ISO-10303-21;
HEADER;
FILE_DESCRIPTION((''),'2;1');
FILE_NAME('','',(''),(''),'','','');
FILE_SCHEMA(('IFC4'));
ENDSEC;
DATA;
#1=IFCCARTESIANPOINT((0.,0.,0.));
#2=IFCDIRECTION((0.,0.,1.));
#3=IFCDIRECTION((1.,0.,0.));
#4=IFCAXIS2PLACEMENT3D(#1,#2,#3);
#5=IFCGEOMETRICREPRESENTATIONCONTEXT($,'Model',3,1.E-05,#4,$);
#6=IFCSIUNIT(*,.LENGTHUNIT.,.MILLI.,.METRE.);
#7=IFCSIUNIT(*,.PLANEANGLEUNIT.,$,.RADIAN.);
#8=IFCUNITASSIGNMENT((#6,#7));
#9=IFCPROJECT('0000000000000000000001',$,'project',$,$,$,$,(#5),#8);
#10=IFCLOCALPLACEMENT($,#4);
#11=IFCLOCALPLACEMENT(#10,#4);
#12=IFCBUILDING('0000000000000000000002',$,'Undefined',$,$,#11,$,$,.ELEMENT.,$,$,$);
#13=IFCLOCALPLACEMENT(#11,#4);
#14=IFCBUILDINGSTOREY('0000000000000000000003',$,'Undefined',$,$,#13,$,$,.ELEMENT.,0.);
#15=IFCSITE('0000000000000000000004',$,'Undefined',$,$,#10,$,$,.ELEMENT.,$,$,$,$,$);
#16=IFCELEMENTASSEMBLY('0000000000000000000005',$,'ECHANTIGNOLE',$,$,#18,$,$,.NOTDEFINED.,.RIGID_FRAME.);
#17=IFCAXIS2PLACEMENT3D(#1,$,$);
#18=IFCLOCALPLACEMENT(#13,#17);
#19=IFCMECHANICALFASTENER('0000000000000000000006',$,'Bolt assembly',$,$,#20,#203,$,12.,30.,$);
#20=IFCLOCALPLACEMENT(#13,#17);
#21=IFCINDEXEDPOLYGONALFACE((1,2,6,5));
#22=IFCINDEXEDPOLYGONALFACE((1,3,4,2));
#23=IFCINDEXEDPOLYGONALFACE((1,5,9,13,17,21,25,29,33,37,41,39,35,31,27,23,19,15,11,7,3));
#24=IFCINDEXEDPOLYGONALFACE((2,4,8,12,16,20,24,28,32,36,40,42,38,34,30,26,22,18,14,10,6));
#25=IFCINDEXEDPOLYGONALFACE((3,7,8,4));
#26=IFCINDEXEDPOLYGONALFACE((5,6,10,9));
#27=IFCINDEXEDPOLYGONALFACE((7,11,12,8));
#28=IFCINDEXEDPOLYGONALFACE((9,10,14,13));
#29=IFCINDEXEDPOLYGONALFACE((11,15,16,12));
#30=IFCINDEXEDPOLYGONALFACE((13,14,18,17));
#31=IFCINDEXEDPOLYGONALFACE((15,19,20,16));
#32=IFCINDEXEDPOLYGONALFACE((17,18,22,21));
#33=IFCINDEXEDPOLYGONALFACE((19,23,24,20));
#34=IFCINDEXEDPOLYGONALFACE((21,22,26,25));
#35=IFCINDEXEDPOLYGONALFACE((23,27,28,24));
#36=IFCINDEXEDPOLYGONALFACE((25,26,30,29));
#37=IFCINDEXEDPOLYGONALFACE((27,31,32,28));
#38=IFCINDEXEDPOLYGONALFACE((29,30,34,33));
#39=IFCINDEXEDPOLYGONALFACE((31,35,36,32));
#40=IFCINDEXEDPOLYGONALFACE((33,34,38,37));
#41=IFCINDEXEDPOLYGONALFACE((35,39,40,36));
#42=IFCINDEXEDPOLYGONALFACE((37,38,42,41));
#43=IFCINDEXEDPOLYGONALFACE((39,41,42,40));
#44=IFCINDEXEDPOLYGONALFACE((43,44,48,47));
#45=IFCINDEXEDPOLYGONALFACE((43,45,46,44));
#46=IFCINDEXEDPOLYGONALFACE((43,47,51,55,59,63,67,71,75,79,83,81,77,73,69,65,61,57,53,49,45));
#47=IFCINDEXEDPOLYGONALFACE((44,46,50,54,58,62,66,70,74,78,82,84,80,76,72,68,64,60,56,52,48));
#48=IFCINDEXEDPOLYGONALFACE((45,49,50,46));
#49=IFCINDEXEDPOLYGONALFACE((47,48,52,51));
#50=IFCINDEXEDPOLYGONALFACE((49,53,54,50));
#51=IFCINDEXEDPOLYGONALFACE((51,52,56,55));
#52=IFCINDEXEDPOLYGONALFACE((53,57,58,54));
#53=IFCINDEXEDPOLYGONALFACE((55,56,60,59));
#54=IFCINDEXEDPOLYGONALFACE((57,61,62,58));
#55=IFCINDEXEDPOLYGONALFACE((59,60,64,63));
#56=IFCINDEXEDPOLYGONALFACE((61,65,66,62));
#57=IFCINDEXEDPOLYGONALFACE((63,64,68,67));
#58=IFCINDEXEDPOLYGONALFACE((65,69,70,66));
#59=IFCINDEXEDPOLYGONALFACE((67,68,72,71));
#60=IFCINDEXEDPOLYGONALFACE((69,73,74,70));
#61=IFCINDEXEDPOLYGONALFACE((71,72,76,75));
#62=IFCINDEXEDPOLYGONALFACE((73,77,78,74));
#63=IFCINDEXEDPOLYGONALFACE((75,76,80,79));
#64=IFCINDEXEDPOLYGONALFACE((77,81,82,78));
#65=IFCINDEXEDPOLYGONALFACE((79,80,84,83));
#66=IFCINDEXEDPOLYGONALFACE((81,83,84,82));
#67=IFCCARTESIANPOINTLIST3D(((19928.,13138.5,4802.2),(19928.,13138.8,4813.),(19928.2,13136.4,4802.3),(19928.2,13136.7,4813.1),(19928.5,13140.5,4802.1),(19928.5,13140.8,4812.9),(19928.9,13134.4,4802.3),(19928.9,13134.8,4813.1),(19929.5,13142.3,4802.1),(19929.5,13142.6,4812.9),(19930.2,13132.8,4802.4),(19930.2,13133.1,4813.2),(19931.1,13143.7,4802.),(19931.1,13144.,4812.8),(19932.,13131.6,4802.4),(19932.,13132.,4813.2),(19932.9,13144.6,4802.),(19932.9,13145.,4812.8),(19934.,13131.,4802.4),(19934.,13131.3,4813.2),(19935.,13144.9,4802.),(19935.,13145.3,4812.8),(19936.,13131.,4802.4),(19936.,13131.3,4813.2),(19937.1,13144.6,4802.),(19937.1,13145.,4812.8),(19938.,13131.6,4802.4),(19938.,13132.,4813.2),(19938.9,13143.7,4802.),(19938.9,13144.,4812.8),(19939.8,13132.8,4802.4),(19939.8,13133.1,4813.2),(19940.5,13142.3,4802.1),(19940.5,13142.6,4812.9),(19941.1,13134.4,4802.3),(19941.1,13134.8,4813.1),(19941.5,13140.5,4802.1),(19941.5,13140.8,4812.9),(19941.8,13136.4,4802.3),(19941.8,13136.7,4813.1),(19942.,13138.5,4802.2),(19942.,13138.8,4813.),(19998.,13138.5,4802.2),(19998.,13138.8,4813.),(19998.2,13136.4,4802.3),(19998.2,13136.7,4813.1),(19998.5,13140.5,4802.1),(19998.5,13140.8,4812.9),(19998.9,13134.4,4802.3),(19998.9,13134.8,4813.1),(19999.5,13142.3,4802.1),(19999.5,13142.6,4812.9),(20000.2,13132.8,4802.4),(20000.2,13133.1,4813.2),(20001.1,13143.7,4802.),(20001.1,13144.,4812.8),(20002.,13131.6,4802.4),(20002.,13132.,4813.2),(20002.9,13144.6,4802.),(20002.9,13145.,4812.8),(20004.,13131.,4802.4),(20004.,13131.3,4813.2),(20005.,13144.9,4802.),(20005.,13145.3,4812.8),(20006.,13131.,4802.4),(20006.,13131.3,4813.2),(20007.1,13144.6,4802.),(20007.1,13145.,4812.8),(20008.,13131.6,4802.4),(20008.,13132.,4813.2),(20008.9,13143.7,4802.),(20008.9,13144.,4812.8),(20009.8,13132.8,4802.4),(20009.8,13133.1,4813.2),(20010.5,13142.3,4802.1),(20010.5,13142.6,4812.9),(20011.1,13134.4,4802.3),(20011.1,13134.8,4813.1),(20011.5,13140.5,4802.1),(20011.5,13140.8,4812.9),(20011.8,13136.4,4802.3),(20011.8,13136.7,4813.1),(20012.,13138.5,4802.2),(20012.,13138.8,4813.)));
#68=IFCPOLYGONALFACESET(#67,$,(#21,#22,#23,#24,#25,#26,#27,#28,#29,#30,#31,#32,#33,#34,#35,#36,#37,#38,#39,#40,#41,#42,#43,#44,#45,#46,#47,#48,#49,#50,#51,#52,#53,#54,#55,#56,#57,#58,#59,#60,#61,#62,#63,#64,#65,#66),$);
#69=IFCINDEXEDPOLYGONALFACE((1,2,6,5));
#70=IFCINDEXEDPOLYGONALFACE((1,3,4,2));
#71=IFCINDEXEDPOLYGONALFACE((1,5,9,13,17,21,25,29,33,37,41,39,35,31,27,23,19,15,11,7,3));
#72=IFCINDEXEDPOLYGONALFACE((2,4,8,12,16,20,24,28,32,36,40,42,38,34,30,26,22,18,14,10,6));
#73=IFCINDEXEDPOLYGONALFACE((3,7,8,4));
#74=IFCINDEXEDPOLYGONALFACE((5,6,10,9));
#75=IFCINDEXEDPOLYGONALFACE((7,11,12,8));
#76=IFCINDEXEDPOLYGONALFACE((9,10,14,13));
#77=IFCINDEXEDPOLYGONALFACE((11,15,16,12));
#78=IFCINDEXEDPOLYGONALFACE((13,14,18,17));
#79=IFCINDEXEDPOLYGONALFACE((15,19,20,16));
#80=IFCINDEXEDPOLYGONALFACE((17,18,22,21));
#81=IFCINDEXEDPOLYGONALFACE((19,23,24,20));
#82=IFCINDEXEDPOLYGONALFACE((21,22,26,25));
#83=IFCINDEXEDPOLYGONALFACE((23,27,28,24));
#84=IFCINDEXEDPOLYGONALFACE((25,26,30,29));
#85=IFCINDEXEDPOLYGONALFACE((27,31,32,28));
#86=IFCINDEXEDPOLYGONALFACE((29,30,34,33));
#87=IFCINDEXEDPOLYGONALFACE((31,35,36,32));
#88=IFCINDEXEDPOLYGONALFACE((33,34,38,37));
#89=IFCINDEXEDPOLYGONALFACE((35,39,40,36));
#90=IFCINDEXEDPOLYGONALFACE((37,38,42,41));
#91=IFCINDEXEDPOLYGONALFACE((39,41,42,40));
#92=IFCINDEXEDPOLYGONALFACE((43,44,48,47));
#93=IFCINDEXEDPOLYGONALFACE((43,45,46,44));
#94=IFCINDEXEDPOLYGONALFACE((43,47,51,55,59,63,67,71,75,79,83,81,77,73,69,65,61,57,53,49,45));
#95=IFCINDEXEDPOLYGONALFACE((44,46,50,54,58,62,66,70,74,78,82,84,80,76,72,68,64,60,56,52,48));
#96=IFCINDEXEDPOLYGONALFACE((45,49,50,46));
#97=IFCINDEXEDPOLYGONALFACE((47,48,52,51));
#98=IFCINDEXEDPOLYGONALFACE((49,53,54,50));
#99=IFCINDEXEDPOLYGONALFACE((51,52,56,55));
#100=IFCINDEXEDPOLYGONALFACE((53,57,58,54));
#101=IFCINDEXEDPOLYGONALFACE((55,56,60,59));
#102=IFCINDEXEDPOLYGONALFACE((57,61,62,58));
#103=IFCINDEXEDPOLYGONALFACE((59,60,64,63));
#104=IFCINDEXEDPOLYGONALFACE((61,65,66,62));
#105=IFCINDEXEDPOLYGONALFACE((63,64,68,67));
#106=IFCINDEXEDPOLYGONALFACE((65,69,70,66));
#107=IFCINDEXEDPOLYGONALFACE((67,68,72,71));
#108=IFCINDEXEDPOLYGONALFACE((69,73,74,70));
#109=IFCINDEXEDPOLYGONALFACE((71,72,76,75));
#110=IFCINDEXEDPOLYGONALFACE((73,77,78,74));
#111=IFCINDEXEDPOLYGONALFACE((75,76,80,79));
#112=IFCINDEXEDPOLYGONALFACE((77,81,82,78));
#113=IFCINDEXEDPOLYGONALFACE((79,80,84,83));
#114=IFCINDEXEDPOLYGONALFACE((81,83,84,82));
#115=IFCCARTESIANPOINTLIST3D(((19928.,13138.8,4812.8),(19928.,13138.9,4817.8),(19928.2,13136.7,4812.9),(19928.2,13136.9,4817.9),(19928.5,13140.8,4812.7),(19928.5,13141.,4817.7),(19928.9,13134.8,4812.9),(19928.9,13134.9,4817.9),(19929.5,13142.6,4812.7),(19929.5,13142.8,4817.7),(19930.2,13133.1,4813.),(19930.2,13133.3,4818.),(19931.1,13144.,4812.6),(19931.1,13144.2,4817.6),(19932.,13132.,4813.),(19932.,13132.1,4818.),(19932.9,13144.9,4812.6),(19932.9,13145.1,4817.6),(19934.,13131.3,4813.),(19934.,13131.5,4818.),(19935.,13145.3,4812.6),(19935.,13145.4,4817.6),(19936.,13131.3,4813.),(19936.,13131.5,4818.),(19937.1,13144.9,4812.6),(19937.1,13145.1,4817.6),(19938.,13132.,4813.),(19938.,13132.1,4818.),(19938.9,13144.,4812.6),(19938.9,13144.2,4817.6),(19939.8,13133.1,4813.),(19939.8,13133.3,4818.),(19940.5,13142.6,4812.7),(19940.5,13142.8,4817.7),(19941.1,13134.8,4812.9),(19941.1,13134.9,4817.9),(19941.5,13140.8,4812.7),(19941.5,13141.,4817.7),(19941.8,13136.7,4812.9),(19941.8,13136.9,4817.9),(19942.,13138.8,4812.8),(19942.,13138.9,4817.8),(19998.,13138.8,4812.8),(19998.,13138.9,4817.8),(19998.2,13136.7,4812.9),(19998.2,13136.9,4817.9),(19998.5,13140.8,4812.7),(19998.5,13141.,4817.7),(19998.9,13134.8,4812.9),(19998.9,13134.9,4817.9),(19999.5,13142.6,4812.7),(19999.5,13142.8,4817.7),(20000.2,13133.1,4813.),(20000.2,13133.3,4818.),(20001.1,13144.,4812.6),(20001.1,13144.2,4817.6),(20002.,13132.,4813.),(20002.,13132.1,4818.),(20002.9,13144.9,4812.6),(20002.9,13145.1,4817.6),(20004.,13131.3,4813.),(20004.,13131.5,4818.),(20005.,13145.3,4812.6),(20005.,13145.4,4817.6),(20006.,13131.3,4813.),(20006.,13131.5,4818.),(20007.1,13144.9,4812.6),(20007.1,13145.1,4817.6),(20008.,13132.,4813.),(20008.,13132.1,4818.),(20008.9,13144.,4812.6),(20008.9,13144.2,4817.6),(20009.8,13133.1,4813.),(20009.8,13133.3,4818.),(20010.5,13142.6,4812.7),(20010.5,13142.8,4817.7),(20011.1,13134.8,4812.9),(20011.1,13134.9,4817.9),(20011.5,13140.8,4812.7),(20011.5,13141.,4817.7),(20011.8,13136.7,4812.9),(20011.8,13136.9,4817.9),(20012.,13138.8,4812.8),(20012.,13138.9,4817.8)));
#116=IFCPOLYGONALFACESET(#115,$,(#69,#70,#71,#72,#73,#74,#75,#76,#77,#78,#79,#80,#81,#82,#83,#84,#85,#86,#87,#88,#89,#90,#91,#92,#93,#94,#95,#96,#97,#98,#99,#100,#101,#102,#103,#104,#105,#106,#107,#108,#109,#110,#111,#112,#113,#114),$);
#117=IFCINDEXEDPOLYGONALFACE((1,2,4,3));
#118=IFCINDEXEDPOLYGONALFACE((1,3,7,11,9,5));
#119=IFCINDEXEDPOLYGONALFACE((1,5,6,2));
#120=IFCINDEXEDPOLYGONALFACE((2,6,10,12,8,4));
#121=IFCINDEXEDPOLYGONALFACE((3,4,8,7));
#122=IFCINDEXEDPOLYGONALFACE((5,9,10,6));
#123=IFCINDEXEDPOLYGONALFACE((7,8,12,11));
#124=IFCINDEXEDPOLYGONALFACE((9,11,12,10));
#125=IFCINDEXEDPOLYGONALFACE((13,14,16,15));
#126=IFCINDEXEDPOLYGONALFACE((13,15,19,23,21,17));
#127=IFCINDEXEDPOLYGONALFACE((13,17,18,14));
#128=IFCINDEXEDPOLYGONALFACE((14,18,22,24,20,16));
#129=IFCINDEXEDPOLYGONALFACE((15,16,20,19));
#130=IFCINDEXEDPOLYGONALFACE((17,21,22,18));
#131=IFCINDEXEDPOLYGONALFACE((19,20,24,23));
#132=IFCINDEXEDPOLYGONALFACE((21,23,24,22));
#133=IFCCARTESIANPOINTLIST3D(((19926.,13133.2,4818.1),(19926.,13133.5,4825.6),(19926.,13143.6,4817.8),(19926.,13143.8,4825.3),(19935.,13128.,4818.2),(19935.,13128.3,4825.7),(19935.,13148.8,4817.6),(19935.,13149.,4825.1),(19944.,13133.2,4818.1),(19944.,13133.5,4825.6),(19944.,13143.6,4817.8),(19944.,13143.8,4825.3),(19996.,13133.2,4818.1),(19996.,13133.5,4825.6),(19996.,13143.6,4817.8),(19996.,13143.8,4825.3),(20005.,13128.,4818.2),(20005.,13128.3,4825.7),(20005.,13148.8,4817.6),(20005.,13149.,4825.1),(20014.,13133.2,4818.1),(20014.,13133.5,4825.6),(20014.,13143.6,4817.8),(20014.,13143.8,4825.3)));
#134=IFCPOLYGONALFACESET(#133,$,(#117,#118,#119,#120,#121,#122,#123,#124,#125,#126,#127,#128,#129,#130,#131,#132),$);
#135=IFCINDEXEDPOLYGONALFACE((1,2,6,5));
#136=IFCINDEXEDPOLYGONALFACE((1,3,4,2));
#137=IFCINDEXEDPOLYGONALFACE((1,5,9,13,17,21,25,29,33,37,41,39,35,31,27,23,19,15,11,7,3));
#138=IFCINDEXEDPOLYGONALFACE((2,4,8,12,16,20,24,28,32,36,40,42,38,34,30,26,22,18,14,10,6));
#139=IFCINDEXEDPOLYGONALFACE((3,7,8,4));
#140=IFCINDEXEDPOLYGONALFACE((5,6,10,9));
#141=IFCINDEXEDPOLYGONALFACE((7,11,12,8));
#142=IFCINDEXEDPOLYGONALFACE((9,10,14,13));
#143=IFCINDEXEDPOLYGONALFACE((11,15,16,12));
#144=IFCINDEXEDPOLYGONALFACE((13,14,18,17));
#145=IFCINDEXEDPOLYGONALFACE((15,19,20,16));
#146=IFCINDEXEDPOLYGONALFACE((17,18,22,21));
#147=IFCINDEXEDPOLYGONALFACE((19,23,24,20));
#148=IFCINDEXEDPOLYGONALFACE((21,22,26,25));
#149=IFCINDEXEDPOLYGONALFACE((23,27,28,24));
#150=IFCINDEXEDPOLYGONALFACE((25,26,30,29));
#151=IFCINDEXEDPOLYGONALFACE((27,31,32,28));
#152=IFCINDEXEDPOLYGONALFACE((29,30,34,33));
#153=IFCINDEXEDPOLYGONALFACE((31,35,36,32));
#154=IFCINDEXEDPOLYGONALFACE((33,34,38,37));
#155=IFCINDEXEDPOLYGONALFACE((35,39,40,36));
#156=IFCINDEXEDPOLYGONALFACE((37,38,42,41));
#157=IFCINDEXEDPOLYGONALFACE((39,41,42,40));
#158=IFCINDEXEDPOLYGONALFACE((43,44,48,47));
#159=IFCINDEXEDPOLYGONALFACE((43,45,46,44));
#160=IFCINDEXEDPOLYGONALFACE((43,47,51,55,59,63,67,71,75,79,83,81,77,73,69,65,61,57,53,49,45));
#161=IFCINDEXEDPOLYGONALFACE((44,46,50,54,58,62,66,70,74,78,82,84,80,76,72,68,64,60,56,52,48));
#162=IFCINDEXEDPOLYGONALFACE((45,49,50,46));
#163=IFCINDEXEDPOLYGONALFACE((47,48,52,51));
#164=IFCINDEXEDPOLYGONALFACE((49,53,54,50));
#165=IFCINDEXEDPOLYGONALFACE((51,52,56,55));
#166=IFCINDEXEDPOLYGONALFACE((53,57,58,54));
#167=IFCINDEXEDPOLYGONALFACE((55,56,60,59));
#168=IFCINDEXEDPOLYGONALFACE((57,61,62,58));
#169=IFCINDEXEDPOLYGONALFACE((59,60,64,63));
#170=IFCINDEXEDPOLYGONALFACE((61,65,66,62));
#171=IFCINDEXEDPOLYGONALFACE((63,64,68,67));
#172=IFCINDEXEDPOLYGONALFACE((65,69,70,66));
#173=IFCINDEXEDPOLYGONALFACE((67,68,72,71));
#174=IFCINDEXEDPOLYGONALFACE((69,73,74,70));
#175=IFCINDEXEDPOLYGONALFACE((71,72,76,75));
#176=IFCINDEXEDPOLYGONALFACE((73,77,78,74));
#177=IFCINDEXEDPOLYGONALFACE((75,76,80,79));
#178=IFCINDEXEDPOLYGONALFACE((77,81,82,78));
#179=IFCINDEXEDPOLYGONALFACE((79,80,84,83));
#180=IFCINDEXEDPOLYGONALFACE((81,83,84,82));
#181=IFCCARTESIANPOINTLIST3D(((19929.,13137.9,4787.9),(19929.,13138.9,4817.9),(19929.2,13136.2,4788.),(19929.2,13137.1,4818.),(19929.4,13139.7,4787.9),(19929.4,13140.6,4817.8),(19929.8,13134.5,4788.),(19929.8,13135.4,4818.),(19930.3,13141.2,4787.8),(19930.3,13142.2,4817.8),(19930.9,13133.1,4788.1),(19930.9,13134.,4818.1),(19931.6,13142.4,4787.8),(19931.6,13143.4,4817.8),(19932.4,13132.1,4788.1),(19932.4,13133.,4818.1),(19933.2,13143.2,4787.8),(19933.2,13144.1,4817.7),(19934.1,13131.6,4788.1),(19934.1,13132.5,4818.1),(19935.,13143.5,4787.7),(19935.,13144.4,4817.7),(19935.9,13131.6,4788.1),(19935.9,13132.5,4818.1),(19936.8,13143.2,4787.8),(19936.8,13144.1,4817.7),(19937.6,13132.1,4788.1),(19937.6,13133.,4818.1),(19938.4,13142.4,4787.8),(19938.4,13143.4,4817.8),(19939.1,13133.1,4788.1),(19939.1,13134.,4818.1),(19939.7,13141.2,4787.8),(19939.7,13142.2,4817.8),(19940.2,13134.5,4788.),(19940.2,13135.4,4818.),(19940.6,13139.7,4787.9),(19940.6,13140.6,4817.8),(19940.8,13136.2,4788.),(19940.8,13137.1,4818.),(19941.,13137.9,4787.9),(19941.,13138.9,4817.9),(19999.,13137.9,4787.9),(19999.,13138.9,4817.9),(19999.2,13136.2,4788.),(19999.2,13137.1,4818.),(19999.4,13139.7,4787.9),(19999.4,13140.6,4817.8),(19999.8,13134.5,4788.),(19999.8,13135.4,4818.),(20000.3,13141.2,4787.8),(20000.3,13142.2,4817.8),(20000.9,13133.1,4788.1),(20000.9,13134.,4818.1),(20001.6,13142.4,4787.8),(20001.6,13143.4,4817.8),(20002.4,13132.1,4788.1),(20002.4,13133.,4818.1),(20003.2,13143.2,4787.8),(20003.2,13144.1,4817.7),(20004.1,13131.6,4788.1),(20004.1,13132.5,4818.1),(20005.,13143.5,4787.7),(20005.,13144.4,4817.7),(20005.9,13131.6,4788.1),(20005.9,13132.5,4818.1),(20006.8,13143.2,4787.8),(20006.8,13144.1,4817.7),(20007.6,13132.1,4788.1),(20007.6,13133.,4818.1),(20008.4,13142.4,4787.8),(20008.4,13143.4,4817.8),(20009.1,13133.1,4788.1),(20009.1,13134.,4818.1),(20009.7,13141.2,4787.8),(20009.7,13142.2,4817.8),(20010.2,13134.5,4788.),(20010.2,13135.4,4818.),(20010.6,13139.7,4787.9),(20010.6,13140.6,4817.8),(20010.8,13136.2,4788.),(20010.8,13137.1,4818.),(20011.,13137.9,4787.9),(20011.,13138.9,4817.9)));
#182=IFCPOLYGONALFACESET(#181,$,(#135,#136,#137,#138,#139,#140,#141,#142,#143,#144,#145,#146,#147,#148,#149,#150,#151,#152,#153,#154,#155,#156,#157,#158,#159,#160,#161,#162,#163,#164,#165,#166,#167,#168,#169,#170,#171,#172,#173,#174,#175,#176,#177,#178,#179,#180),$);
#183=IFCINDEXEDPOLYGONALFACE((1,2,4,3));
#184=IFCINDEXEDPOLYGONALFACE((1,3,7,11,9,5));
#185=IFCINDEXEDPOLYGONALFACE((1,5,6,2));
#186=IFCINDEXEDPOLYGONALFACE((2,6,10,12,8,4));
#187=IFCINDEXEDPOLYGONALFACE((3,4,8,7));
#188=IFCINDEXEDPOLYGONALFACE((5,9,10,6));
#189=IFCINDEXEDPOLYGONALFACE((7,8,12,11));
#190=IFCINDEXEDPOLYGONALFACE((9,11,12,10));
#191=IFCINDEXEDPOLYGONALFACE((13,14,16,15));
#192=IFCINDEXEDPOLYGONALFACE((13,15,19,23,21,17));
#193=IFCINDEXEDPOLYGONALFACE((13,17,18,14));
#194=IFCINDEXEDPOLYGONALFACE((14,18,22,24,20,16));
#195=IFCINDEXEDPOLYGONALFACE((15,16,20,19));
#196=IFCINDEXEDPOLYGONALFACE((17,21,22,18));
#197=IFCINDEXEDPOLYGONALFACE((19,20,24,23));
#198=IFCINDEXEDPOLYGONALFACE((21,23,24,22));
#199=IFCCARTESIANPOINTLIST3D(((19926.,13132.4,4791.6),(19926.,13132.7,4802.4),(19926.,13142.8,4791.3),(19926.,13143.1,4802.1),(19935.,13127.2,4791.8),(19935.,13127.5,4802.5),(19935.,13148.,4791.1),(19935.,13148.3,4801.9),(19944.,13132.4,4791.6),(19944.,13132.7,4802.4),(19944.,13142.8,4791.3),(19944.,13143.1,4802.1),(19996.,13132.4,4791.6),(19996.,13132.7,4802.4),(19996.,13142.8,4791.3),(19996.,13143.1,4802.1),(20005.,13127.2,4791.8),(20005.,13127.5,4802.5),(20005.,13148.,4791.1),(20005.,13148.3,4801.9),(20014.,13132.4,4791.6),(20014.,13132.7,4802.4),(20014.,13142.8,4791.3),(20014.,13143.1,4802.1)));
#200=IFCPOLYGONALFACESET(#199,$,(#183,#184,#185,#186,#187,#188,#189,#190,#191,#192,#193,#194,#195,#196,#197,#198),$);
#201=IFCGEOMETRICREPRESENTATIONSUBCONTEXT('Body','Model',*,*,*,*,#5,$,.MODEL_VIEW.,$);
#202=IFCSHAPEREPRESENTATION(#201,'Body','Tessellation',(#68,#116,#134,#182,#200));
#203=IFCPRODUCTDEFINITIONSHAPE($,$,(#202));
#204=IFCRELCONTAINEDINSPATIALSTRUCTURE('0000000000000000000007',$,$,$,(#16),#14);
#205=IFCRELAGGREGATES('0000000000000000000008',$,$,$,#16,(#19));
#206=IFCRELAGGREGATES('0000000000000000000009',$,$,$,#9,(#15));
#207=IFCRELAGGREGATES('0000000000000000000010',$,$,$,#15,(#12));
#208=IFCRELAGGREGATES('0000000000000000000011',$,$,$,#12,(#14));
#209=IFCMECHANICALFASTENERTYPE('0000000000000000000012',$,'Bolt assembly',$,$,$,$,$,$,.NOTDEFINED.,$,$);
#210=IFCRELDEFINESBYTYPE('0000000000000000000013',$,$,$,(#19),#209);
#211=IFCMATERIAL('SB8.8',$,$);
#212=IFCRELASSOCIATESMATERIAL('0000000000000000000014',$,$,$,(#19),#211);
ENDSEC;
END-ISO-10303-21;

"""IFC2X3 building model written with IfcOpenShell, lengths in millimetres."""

from ifc_helpers import new_model, si_unit, frame, origin_with_axes, origin_2d_with_axis, place, context, subcontext, project, spatial, polyline, circle, outline, extrude, source, transform, mapped, material, type_object, element, aggregate, save


model = new_model("IFC2X3")

# Units and contexts
model_context = context("Model", 3, precision=1e-05, world=origin_with_axes())
body_context = subcontext(model_context, "Body", "Model", "MODEL_VIEW")
ifc_project = project(units=[si_unit("LENGTHUNIT", "METRE", prefix="MILLI"), si_unit("PLANEANGLEUNIT", "RADIAN")], contexts=[model_context])

# Site, building, storey
site_placement = place(None, origin_with_axes())
site = spatial("IfcSite", under=ifc_project, at=site_placement, Name="Undefined", CompositionType="ELEMENT")
building_placement = place(site_placement, origin_with_axes())
building = spatial("IfcBuilding", under=site, at=building_placement, Name="Undefined", CompositionType="ELEMENT")
storey_placement = place(building_placement, origin_with_axes())
storey = spatial("IfcBuildingStorey", under=building, at=storey_placement, Name="Undefined", CompositionType="ELEMENT", Elevation=0.0)

# Shared definitions
ifc_material_1 = material(Name="SB8.8")
mechanical_fastener_type = type_object("IfcMechanicalFastenerType", Name="Bolt assembly")

# Element assembly, mechanical fastener
assembly_1_placement = place(storey_placement, origin_with_axes())
assembly_1 = element("IfcElementAssembly", 1, at=assembly_1_placement, inside=storey, Name="ECHANTIGNOLE", AssemblyPlace="NOTDEFINED", PredefinedType="RIGID_FRAME")
shared_shape_1 = source(origin_with_axes(), body_context, "Body", "SweptSolid", [
    extrude(circle(Radius=7.0, at=origin_2d_with_axis()), frame((0.0, -0.1, 0.0), z_axis=(0.0, 1.0, 0.0), x_axis=(1.0, 0.0, 0.0)), (0.0, 0.0, 1.0), 10.8),
    extrude(circle(Radius=7.0, at=origin_2d_with_axis()), frame((0.0, -4.9, 0.0), z_axis=(0.0, 1.0, 0.0), x_axis=(1.0, 0.0, 0.0)), (0.0, 0.0, 1.0), 5.0),
    extrude(outline(polyline([(10.4, 0.0), (5.2, 9.0), (-5.2, 9.0), (-10.4, 0.0), (-5.2, -9.0), (5.2, -9.0), (10.4, 0.0)])), frame((0.0, -12.5, 0.0), z_axis=(0.0, 1.0, 0.0), x_axis=(1.0, 0.0, 0.0)), (0.0, 0.0, 1.0), 7.5),
    extrude(circle(Radius=6.0, at=origin_2d_with_axis()), frame((0.0, -5.0, 0.0), z_axis=(0.0, 1.0, 0.0), x_axis=(1.0, 0.0, 0.0)), (0.0, 0.0, 1.0), 30.0),
    extrude(outline(polyline([(10.4, 0.0), (5.2, 9.0), (-5.2, 9.0), (-10.4, 0.0), (-5.2, -9.0), (5.2, -9.0), (10.4, 0.0)])), frame((0.0, 10.7, 0.0), z_axis=(0.0, 1.0, 0.0), x_axis=(1.0, 0.0, 0.0)), (0.0, 0.0, 1.0), 10.8),
])
mechanical_fastener_1_placement = place(assembly_1_placement, frame((19970.0, 13138.3, 4812.9), z_axis=(-1.0, 0.0, 0.0), x_axis=(0.0, 0.99952, -0.030986)))
mechanical_fastener_1 = element("IfcMechanicalFastener", 2, at=mechanical_fastener_1_placement, type_object=mechanical_fastener_type, material=ifc_material_1, Name="Bolt assembly", NominalDiameter=12.0, NominalLength=30.0, context=body_context, shape_type="MappedRepresentation", body=[
    mapped(shared_shape_1, transform((0.0, 0.0, 35.0))),
    mapped(shared_shape_1, transform((0.0, 0.0, -35.0))),
])
aggregate(assembly_1, [mechanical_fastener_1])

save(model, "model.ifc")
